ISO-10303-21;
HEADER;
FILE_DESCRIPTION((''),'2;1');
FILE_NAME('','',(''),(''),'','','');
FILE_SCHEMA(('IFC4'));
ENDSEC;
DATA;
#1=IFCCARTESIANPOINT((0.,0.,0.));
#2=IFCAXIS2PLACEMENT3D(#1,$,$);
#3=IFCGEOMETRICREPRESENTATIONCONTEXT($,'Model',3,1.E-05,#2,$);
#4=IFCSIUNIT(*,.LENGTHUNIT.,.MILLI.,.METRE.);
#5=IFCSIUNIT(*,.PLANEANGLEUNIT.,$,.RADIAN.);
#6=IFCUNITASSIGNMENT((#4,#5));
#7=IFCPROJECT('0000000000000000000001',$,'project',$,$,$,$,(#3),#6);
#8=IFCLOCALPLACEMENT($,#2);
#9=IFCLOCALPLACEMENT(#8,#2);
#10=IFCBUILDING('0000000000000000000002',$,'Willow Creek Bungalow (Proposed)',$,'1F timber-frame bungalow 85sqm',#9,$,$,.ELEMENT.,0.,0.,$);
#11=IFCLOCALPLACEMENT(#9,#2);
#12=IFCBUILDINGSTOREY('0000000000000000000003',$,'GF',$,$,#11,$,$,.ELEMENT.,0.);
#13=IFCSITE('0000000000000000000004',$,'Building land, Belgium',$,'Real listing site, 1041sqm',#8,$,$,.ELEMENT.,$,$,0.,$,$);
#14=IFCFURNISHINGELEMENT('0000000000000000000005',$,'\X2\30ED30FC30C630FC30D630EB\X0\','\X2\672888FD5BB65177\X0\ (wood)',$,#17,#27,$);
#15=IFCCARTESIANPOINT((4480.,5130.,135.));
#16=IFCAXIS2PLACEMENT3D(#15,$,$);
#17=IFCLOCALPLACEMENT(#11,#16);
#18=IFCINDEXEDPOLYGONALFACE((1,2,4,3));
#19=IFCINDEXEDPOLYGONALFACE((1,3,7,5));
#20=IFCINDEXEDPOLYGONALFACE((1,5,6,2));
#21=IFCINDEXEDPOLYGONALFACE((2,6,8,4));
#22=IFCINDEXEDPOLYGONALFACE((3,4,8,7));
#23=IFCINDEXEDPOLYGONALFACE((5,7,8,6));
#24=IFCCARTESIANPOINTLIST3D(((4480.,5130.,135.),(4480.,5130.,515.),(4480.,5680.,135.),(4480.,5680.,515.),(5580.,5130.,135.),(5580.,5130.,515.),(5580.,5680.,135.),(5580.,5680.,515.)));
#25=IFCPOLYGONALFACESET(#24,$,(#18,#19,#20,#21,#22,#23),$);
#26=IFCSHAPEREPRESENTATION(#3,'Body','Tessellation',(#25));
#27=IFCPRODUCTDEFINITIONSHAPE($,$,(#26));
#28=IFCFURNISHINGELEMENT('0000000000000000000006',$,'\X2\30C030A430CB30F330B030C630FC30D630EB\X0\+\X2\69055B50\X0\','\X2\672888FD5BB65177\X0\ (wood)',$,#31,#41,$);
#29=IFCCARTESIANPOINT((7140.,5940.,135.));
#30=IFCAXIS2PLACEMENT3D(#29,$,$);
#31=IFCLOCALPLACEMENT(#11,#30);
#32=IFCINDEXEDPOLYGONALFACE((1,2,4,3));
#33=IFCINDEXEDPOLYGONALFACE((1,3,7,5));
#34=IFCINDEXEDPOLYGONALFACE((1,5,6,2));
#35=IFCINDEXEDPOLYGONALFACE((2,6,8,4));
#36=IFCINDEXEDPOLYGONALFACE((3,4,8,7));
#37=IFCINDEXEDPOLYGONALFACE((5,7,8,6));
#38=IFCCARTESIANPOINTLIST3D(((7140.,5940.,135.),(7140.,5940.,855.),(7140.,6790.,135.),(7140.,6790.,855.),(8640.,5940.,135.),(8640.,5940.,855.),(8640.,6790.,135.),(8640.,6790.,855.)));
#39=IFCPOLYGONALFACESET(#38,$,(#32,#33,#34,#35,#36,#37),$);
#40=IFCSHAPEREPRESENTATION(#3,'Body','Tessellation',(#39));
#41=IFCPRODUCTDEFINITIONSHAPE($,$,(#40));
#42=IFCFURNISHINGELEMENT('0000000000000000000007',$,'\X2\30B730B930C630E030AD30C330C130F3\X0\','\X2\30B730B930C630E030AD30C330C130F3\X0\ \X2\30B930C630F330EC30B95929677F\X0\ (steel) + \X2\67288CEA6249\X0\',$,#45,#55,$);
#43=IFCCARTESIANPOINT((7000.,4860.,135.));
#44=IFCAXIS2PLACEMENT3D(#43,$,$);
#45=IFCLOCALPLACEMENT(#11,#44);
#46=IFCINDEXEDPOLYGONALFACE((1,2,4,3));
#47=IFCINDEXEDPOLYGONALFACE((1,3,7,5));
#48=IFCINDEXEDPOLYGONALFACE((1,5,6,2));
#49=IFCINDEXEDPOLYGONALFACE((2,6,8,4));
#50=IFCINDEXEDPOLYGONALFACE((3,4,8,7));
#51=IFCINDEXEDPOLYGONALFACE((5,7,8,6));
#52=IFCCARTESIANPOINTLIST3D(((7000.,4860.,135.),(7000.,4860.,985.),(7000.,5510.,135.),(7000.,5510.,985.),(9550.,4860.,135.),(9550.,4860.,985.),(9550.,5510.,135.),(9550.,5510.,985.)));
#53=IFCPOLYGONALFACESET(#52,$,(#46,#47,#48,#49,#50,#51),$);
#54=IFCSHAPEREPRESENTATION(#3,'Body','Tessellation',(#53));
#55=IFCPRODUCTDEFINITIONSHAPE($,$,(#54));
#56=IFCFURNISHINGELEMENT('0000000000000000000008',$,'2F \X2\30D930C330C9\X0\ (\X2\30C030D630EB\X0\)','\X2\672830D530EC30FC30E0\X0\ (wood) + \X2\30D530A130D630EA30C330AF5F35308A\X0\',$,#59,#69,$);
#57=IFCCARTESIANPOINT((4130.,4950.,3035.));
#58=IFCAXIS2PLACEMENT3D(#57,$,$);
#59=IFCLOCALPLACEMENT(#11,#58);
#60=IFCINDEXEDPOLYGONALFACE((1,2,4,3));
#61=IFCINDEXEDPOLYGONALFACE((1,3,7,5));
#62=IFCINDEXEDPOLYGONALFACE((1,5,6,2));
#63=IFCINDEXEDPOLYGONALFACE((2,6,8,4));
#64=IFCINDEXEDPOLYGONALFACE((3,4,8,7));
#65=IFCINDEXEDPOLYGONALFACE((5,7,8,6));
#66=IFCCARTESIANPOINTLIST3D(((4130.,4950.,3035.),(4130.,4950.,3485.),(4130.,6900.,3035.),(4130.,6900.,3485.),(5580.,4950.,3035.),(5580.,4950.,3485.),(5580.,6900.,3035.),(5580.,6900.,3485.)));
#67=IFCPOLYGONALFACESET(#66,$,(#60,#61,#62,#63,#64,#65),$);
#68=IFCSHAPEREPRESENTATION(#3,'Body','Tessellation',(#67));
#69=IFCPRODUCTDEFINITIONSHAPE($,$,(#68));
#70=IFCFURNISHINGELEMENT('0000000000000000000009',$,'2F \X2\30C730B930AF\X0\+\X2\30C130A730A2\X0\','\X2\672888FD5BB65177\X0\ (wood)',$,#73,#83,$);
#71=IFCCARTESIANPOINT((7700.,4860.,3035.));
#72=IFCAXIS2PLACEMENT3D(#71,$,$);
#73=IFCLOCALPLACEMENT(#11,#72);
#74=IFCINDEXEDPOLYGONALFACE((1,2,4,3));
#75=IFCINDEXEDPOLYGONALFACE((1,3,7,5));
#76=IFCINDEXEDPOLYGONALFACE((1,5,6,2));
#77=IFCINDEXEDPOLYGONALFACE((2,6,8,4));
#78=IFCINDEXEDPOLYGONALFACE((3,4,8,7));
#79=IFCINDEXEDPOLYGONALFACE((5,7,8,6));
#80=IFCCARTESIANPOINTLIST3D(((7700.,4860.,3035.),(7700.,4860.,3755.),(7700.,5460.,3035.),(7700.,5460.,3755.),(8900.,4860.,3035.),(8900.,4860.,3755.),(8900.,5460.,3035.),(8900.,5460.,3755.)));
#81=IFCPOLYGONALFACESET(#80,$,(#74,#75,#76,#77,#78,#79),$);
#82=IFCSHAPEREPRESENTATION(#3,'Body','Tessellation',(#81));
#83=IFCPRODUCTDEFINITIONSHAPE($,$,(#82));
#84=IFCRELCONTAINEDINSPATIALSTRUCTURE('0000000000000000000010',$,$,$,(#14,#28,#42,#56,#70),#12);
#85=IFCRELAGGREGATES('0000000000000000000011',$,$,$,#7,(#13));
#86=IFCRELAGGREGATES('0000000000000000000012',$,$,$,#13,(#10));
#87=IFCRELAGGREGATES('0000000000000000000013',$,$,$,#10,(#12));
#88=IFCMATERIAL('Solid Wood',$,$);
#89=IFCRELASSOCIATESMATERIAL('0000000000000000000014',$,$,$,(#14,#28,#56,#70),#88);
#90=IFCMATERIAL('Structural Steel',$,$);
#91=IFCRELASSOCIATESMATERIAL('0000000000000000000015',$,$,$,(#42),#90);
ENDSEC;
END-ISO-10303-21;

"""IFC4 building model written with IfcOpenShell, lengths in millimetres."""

from ifc_helpers import new_model, si_unit, frame, frame_2d, origin, place, context, project, spatial, rectangle, extrude, material, element, save


model = new_model("IFC4")

# Units and contexts
model_context = context("Model", 3, precision=1e-05, world=origin())
ifc_project = project(units=[si_unit("LENGTHUNIT", "METRE", prefix="MILLI"), si_unit("PLANEANGLEUNIT", "RADIAN")], contexts=[model_context])

# Site, building, storey
site_placement = place(None, origin())
site = spatial("IfcSite", under=ifc_project, at=site_placement, Name="Building land, Belgium", ObjectType="Real listing site, 1041sqm", CompositionType="ELEMENT", RefElevation=0.0)
building_placement = place(site_placement, origin())
building = spatial("IfcBuilding", under=site, at=building_placement, Name="Willow Creek Bungalow (Proposed)", ObjectType="1F timber-frame bungalow 85sqm", CompositionType="ELEMENT", ElevationOfRefHeight=0.0, ElevationOfTerrain=0.0)
storey_placement = place(building_placement, origin())
storey = spatial("IfcBuildingStorey", under=building, at=storey_placement, Name="GF", CompositionType="ELEMENT", Elevation=0.0)

# Shared definitions
ifc_material_1 = material(Name="Solid Wood")

# Shared definitions
ifc_material_2 = material(Name="Structural Steel")

# Furnishing elements
furnishing_1_placement = place(storey_placement, frame((4480.0, 5130.0, 135.0)))
element("IfcFurnishingElement", 1, at=furnishing_1_placement, inside=storey, material=ifc_material_1, Name="ローテーブル", Description="木製家具 (wood)", context=model_context, shape_type="SweptSolid", body=[
    extrude(rectangle(XDim=1100.0, YDim=550.0, at=frame_2d((550.0, 275.0))), frame((4480.0, 5130.0, 135.0)), (0.0, 0.0, 1.0), 380.0),
])
furnishing_2_placement = place(storey_placement, frame((7140.0, 5940.0, 135.0)))
element("IfcFurnishingElement", 2, at=furnishing_2_placement, inside=storey, material=ifc_material_1, Name="ダイニングテーブル+椅子", Description="木製家具 (wood)", context=model_context, shape_type="SweptSolid", body=[
    extrude(rectangle(XDim=1500.0, YDim=850.0, at=frame_2d((750.0, 425.0))), frame((7140.0, 5940.0, 135.0)), (0.0, 0.0, 1.0), 720.0),
])
furnishing_3_placement = place(storey_placement, frame((7000.0, 4860.0, 135.0)))
element("IfcFurnishingElement", 3, at=furnishing_3_placement, inside=storey, material=ifc_material_2, Name="システムキッチン", Description="システムキッチン ステンレス天板 (steel) + 木質扉", context=model_context, shape_type="SweptSolid", body=[
    extrude(rectangle(XDim=2550.0, YDim=650.0, at=frame_2d((1275.0, 325.0))), frame((7000.0, 4860.0, 135.0)), (0.0, 0.0, 1.0), 850.0),
])
furnishing_4_placement = place(storey_placement, frame((4130.0, 4950.0, 3035.0)))
element("IfcFurnishingElement", 4, at=furnishing_4_placement, inside=storey, material=ifc_material_1, Name="2F ベッド (ダブル)", Description="木フレーム (wood) + ファブリック張り", context=model_context, shape_type="SweptSolid", body=[
    extrude(rectangle(XDim=1450.0, YDim=1950.0, at=frame_2d((725.0, 975.0))), frame((4130.0, 4950.0, 3035.0)), (0.0, 0.0, 1.0), 450.0),
])
furnishing_5_placement = place(storey_placement, frame((7700.0, 4860.0, 3035.0)))
element("IfcFurnishingElement", 5, at=furnishing_5_placement, inside=storey, material=ifc_material_1, Name="2F デスク+チェア", Description="木製家具 (wood)", context=model_context, shape_type="SweptSolid", body=[
    extrude(rectangle(XDim=1200.0, YDim=600.0, at=frame_2d((600.0, 300.0))), frame((7700.0, 4860.0, 3035.0)), (0.0, 0.0, 1.0), 720.0),
])

save(model, "model.ifc")
